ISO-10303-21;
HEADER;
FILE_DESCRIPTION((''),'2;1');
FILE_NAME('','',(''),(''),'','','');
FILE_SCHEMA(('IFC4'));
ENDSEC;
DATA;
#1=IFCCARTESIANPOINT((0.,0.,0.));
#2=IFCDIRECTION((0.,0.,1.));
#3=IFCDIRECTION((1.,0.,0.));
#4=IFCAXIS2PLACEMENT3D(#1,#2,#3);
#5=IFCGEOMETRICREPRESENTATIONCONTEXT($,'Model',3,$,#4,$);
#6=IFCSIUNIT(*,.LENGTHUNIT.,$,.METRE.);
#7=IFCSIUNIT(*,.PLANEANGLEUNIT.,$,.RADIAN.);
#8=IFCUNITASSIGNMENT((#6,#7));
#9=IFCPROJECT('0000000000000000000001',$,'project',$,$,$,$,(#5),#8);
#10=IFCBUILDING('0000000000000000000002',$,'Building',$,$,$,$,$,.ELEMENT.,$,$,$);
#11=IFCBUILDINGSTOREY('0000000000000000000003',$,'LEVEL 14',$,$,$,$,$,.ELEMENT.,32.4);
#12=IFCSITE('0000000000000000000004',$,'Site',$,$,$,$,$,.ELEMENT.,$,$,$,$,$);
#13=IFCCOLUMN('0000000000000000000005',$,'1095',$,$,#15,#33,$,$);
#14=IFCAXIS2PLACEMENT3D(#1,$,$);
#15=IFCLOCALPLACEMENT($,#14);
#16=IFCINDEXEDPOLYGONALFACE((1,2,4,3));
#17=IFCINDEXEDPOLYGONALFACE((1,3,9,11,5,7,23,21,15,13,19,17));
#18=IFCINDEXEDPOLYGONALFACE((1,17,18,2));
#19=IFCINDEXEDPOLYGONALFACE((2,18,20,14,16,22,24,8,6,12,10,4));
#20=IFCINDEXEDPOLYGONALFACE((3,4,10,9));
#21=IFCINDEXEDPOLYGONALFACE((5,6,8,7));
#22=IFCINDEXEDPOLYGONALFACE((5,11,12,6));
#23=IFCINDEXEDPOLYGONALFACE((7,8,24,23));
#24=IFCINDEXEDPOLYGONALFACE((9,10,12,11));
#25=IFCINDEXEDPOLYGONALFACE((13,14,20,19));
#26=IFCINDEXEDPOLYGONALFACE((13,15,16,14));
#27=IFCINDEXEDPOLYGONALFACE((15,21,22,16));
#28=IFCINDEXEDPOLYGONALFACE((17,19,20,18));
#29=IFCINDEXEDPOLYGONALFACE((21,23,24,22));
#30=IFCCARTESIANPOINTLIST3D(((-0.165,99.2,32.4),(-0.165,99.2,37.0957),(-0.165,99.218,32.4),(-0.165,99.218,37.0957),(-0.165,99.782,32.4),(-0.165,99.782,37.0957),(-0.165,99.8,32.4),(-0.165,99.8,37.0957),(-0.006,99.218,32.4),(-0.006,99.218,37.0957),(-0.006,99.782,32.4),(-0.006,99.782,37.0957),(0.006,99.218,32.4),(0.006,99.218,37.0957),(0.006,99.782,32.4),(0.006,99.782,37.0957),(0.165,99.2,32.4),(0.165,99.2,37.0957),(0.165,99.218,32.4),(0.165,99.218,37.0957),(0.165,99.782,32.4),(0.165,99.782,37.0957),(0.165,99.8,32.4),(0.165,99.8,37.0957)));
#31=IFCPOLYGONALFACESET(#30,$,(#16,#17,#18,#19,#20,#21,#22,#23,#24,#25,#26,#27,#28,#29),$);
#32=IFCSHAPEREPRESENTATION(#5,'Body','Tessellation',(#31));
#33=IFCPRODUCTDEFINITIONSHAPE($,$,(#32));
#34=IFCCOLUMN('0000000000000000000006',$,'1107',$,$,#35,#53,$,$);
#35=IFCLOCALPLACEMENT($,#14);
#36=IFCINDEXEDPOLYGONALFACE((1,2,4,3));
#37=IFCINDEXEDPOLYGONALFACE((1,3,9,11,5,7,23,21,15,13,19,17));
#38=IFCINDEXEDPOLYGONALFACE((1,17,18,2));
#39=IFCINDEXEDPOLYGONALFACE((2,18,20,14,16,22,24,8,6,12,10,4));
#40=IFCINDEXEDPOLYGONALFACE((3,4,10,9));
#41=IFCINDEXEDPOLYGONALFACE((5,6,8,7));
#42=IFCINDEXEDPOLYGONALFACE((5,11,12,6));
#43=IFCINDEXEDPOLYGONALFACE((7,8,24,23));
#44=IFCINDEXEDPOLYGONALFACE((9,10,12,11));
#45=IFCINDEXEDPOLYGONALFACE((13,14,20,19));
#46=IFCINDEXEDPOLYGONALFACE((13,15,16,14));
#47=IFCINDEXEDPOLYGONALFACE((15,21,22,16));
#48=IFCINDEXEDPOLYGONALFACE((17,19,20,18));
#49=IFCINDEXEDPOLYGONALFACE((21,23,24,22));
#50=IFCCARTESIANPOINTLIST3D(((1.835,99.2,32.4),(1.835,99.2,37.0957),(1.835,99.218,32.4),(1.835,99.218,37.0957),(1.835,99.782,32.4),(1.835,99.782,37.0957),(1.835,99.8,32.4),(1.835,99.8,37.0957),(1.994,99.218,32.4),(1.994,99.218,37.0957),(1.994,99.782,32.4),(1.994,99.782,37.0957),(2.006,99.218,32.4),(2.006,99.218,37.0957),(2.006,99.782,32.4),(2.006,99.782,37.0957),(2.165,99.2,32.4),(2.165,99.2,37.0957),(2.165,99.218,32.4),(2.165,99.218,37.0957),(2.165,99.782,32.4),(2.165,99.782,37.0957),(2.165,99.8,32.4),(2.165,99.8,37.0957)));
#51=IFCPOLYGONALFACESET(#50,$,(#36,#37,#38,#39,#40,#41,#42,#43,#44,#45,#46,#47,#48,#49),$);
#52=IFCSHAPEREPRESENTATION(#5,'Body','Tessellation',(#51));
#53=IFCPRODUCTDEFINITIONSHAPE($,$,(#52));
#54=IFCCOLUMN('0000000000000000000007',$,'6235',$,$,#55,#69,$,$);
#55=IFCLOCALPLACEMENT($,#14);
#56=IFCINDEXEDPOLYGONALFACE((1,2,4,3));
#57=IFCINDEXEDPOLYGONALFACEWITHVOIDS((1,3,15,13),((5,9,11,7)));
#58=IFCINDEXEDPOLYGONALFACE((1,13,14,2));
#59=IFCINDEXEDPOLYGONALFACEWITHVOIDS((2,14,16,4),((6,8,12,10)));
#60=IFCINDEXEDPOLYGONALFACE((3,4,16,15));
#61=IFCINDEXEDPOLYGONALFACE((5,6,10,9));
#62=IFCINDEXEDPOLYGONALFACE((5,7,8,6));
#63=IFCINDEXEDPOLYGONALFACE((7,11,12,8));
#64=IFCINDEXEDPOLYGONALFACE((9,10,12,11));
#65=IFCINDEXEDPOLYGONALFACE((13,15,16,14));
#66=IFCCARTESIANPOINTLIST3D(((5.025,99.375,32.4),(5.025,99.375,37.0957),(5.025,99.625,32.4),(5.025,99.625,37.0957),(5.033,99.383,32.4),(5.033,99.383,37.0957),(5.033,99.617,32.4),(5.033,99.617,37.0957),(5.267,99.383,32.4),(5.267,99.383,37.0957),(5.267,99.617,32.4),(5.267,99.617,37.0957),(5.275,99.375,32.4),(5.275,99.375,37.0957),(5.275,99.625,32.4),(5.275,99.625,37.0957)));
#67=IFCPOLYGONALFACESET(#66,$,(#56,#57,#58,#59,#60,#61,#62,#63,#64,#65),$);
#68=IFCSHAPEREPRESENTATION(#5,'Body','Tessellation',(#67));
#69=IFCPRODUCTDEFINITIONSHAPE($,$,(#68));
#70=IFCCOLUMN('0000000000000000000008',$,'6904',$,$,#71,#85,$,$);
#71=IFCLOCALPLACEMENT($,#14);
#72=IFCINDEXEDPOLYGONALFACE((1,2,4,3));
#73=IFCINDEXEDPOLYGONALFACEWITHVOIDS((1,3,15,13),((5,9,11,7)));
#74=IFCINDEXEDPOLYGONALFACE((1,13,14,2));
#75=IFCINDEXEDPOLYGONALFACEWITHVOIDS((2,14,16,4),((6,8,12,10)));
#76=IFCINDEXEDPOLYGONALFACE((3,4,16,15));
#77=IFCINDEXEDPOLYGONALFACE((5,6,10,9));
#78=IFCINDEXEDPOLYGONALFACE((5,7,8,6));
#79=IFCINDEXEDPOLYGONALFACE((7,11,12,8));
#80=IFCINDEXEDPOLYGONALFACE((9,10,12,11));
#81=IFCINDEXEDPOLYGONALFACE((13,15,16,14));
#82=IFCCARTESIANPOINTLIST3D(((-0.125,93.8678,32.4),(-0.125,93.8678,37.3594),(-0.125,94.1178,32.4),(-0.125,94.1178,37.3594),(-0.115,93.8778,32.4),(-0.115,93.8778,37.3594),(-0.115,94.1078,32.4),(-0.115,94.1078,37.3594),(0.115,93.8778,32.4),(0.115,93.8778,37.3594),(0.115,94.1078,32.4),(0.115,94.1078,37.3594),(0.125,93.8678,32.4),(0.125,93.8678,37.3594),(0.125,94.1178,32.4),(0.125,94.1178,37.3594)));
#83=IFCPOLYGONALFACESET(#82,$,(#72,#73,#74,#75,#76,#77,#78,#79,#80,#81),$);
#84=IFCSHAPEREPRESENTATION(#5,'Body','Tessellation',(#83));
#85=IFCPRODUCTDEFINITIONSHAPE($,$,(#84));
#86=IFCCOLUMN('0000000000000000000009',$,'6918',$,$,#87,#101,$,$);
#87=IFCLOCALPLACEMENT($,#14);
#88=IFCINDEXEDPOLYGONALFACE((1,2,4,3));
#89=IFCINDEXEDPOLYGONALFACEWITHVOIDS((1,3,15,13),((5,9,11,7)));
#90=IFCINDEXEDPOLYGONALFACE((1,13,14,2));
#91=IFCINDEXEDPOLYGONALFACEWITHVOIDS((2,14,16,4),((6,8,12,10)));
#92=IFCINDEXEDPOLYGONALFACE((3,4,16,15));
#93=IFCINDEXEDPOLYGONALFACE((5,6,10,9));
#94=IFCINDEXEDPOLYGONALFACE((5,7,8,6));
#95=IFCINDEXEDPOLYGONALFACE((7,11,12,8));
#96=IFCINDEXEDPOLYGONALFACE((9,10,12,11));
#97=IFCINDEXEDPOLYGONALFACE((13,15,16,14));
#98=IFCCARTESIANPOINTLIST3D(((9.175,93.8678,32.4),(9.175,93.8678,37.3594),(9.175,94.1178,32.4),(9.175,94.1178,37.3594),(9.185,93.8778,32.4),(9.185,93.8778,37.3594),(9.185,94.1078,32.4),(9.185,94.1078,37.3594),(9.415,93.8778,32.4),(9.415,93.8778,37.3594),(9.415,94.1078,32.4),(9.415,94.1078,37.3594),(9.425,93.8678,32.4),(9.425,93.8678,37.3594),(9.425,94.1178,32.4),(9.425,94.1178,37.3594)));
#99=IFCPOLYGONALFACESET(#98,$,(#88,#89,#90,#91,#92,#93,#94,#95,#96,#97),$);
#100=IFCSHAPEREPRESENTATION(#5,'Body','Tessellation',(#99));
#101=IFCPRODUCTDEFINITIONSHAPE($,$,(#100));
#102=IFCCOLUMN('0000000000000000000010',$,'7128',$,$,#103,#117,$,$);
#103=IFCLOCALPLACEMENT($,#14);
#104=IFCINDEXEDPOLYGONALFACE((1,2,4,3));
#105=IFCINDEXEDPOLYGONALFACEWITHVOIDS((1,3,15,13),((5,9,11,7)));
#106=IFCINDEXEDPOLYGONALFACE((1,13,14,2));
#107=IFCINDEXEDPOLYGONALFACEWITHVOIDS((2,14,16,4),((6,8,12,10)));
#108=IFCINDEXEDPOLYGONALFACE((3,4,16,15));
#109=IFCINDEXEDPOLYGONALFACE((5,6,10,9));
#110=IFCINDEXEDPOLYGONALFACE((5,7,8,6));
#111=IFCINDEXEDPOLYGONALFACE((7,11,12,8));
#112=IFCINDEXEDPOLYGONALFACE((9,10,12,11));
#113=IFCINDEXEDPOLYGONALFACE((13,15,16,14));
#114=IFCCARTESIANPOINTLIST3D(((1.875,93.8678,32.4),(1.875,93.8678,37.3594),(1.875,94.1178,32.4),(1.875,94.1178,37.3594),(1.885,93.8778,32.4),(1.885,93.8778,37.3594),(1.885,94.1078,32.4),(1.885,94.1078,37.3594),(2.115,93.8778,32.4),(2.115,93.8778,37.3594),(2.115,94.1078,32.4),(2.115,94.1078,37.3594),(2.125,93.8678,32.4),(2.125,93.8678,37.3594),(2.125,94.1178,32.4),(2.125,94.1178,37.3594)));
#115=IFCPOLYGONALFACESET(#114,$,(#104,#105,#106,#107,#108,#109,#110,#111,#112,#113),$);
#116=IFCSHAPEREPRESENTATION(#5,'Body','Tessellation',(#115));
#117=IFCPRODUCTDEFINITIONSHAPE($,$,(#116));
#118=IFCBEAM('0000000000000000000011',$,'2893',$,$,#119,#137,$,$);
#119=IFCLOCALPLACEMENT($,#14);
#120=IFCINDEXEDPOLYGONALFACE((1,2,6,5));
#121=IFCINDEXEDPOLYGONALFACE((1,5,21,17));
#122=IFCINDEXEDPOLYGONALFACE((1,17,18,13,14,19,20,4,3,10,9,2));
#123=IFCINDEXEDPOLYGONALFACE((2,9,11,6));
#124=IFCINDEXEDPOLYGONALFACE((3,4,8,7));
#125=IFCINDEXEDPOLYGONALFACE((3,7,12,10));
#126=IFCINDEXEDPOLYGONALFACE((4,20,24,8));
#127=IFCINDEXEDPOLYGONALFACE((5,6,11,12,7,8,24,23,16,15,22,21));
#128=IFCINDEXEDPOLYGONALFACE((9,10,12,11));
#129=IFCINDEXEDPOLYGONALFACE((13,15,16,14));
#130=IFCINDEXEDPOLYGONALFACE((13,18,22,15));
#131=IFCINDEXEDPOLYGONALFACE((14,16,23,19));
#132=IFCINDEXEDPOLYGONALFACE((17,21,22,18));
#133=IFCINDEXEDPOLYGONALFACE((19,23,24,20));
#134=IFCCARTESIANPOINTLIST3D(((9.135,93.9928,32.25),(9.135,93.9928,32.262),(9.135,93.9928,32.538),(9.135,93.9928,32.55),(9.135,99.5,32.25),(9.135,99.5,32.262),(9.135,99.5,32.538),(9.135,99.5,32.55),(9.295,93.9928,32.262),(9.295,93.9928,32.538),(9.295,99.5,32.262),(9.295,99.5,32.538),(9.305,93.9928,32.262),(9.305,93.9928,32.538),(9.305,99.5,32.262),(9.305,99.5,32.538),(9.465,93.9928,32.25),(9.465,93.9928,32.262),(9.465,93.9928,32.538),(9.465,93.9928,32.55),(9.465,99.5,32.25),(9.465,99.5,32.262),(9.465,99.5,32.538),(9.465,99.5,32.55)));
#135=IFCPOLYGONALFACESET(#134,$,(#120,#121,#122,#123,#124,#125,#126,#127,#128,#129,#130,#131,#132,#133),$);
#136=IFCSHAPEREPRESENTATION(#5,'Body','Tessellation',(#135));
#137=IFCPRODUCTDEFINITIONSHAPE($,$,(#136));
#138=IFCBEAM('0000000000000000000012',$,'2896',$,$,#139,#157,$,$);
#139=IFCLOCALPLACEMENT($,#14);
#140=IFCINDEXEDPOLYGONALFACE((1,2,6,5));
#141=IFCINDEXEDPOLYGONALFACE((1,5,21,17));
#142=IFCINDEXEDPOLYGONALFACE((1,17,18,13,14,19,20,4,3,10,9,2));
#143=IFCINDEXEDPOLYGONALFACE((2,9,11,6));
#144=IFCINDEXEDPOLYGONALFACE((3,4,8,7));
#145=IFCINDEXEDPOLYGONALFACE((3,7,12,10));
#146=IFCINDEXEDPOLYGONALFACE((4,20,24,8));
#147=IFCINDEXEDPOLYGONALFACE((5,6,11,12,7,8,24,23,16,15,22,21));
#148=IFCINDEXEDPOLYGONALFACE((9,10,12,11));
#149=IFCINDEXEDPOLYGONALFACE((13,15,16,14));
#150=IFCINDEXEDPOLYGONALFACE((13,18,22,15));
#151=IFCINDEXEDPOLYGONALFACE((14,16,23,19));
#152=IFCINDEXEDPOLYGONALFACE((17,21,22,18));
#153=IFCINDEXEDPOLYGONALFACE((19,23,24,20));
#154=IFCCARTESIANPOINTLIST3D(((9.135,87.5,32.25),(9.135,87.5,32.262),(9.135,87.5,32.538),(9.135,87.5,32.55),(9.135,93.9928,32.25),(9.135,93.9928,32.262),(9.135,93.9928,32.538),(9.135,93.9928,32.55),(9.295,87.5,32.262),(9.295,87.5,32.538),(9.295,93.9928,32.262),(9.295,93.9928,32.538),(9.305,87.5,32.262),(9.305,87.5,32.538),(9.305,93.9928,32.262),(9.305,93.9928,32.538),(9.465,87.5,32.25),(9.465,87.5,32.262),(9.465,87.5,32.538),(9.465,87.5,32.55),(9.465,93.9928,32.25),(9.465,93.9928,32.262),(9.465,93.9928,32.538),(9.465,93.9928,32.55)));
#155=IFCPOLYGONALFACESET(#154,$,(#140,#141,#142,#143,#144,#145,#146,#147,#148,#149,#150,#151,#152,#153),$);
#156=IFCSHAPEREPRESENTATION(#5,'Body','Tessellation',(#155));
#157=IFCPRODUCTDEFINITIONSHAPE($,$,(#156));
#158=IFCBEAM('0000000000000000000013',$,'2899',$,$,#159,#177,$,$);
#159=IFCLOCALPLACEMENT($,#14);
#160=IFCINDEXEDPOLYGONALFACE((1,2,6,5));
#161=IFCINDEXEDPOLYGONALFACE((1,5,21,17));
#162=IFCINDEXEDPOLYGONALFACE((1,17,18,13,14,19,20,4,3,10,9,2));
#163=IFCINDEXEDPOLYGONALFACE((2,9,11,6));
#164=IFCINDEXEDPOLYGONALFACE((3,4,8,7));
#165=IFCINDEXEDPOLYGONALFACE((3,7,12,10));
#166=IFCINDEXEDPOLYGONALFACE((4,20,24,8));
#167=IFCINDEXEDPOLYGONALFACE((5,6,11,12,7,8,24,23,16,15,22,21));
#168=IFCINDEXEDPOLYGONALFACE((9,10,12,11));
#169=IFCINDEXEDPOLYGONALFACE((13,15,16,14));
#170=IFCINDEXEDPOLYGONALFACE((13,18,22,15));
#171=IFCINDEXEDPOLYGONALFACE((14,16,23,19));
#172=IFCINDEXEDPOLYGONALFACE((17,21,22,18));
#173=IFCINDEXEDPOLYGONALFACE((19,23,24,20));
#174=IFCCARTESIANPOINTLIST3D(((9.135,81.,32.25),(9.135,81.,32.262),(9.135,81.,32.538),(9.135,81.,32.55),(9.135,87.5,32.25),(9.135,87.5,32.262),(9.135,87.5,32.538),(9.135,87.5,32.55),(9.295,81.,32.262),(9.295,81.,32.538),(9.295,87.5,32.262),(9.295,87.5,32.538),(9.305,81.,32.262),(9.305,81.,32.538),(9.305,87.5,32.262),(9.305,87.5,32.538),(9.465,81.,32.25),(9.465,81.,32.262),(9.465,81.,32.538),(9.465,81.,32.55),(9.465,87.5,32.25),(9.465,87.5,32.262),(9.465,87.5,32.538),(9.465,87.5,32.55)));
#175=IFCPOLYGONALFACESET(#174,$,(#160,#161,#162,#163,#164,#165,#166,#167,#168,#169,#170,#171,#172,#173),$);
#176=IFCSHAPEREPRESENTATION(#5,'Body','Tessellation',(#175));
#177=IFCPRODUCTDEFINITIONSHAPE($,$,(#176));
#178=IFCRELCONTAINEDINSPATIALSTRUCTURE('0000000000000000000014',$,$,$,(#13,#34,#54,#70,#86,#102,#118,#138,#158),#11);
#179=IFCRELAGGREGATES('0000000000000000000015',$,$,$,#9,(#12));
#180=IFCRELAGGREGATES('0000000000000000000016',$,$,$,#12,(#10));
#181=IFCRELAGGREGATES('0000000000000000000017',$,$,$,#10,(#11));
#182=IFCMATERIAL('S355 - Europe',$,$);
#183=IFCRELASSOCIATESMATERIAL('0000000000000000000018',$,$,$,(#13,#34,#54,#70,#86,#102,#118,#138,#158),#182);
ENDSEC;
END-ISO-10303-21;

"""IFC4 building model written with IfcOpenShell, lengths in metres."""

from ifc_helpers import new_model, si_unit, frame, origin_with_axes, origin_2d_with_axis, place, context, project, spatial, hollow_rectangle, i_section, extrude, material, material_profile, profile_set, profile_usage, element, save


model = new_model("IFC4")

# Units and contexts
model_context = context("Model", 3, world=origin_with_axes())
ifc_project = project(units=[si_unit("LENGTHUNIT", "METRE"), si_unit("PLANEANGLEUNIT", "RADIAN")], contexts=[model_context])

# Site, building, storey
site = spatial("IfcSite", under=ifc_project, Name="Site", CompositionType="ELEMENT")
building = spatial("IfcBuilding", under=site, Name="Building", CompositionType="ELEMENT")
storey = spatial("IfcBuildingStorey", under=building, Name="LEVEL 14", CompositionType="ELEMENT", Elevation=32.4)

# Columns
ifc_material = material(Name="S355 - Europe")
ifc_material_profile_1 = material_profile(ifc_material, i_section(OverallWidth=0.33, OverallDepth=0.6, WebThickness=0.012, FlangeThickness=0.018, at=origin_2d_with_axis()))
ifc_profile_set_1 = profile_set([ifc_material_profile_1])
ifc_profile_usage_1 = profile_usage(ifc_profile_set_1, cardinal=10)
column_1_placement = place(None, frame((0.0, 99.5, 32.4), z_axis=(0.0, 0.0, 1.0), x_axis=(1.0, 0.0, 0.0)))
element("IfcColumn", 1, at=column_1_placement, inside=storey, material=ifc_profile_usage_1, Name="1095", context=model_context, shape_type="SweptSolid", body=[
    extrude(i_section(OverallWidth=0.33, OverallDepth=0.6, WebThickness=0.012, FlangeThickness=0.018, at=origin_2d_with_axis()), origin_with_axes(), (0.0, 0.0, 1.0), 4.6957),
])
ifc_material_profile_2 = material_profile(ifc_material, i_section(OverallWidth=0.33, OverallDepth=0.6, WebThickness=0.012, FlangeThickness=0.018, at=origin_2d_with_axis()))
ifc_profile_set_2 = profile_set([ifc_material_profile_2])
ifc_profile_usage_2 = profile_usage(ifc_profile_set_2, cardinal=10)
column_2_placement = place(None, frame((2.0, 99.5, 32.4), z_axis=(0.0, 0.0, 1.0), x_axis=(1.0, 0.0, 0.0)))
element("IfcColumn", 2, at=column_2_placement, inside=storey, material=ifc_profile_usage_2, Name="1107", context=model_context, shape_type="SweptSolid", body=[
    extrude(i_section(OverallWidth=0.33, OverallDepth=0.6, WebThickness=0.012, FlangeThickness=0.018, at=origin_2d_with_axis()), origin_with_axes(), (0.0, 0.0, 1.0), 4.6957),
])
ifc_material_profile_3 = material_profile(ifc_material, hollow_rectangle(XDim=0.25, YDim=0.25, WallThickness=0.008, at=origin_2d_with_axis()))
ifc_profile_set_3 = profile_set([ifc_material_profile_3])
ifc_profile_usage_3 = profile_usage(ifc_profile_set_3, cardinal=10)
column_3_placement = place(None, frame((5.15, 99.5, 32.4), z_axis=(0.0, 0.0, 1.0), x_axis=(0.0, -1.0, 0.0)))
element("IfcColumn", 3, at=column_3_placement, inside=storey, material=ifc_profile_usage_3, Name="6235", context=model_context, shape_type="SweptSolid", body=[
    extrude(hollow_rectangle(XDim=0.25, YDim=0.25, WallThickness=0.008, at=origin_2d_with_axis()), origin_with_axes(), (0.0, 0.0, 1.0), 4.6957),
])
ifc_material_profile_4 = material_profile(ifc_material, hollow_rectangle(XDim=0.25, YDim=0.25, WallThickness=0.01, at=origin_2d_with_axis()))
ifc_profile_set_4 = profile_set([ifc_material_profile_4])
ifc_profile_usage_4 = profile_usage(ifc_profile_set_4, cardinal=10)
column_4_placement = place(None, frame((0.0, 93.9928, 32.4), z_axis=(0.0, 0.0, 1.0), x_axis=(0.0, -1.0, 0.0)))
element("IfcColumn", 4, at=column_4_placement, inside=storey, material=ifc_profile_usage_4, Name="6904", context=model_context, shape_type="SweptSolid", body=[
    extrude(hollow_rectangle(XDim=0.25, YDim=0.25, WallThickness=0.01, at=origin_2d_with_axis()), origin_with_axes(), (0.0, 0.0, 1.0), 4.9594),
])
ifc_material_profile_5 = material_profile(ifc_material, hollow_rectangle(XDim=0.25, YDim=0.25, WallThickness=0.01, at=origin_2d_with_axis()))
ifc_profile_set_5 = profile_set([ifc_material_profile_5])
ifc_profile_usage_5 = profile_usage(ifc_profile_set_5, cardinal=10)
column_5_placement = place(None, frame((9.3, 93.9928, 32.4), z_axis=(0.0, 0.0, 1.0), x_axis=(0.0, -1.0, 0.0)))
element("IfcColumn", 5, at=column_5_placement, inside=storey, material=ifc_profile_usage_5, Name="6918", context=model_context, shape_type="SweptSolid", body=[
    extrude(hollow_rectangle(XDim=0.25, YDim=0.25, WallThickness=0.01, at=origin_2d_with_axis()), origin_with_axes(), (0.0, 0.0, 1.0), 4.9594),
])
ifc_material_profile_6 = material_profile(ifc_material, hollow_rectangle(XDim=0.25, YDim=0.25, WallThickness=0.01, at=origin_2d_with_axis()))
ifc_profile_set_6 = profile_set([ifc_material_profile_6])
ifc_profile_usage_6 = profile_usage(ifc_profile_set_6, cardinal=10)
column_6_placement = place(None, frame((2.0, 93.9928, 32.4), z_axis=(0.0, 0.0, 1.0), x_axis=(0.0, -1.0, 0.0)))
element("IfcColumn", 6, at=column_6_placement, inside=storey, material=ifc_profile_usage_6, Name="7128", context=model_context, shape_type="SweptSolid", body=[
    extrude(hollow_rectangle(XDim=0.25, YDim=0.25, WallThickness=0.01, at=origin_2d_with_axis()), origin_with_axes(), (0.0, 0.0, 1.0), 4.9594),
])

# Beams
ifc_material_profile_7 = material_profile(ifc_material, i_section(OverallWidth=0.33, OverallDepth=0.3, WebThickness=0.01, FlangeThickness=0.012, at=origin_2d_with_axis()))
ifc_profile_set_7 = profile_set([ifc_material_profile_7])
ifc_profile_usage_7 = profile_usage(ifc_profile_set_7, cardinal=10)
beam_1_placement = place(None, frame((9.3, 93.9928, 32.4), z_axis=(0.0, 1.0, 0.0), x_axis=(-1.0, 0.0, 0.0)))
element("IfcBeam", 7, at=beam_1_placement, inside=storey, material=ifc_profile_usage_7, Name="2893", context=model_context, shape_type="SweptSolid", body=[
    extrude(i_section(OverallWidth=0.33, OverallDepth=0.3, WebThickness=0.01, FlangeThickness=0.012, at=origin_2d_with_axis()), origin_with_axes(), (0.0, 0.0, 1.0), 5.5072),
])
ifc_material_profile_8 = material_profile(ifc_material, i_section(OverallWidth=0.33, OverallDepth=0.3, WebThickness=0.01, FlangeThickness=0.012, at=origin_2d_with_axis()))
ifc_profile_set_8 = profile_set([ifc_material_profile_8])
ifc_profile_usage_8 = profile_usage(ifc_profile_set_8, cardinal=10)
beam_2_placement = place(None, frame((9.3, 93.9928, 32.4), z_axis=(0.0, -1.0, 0.0), x_axis=(1.0, 0.0, 0.0)))
element("IfcBeam", 8, at=beam_2_placement, inside=storey, material=ifc_profile_usage_8, Name="2896", context=model_context, shape_type="SweptSolid", body=[
    extrude(i_section(OverallWidth=0.33, OverallDepth=0.3, WebThickness=0.01, FlangeThickness=0.012, at=origin_2d_with_axis()), origin_with_axes(), (0.0, 0.0, 1.0), 6.4928),
])
ifc_material_profile_9 = material_profile(ifc_material, i_section(OverallWidth=0.33, OverallDepth=0.3, WebThickness=0.01, FlangeThickness=0.012, at=origin_2d_with_axis()))
ifc_profile_set_9 = profile_set([ifc_material_profile_9])
ifc_profile_usage_9 = profile_usage(ifc_profile_set_9, cardinal=10)
beam_3_placement = place(None, frame((9.3, 87.5, 32.4), z_axis=(0.0, -1.0, 0.0), x_axis=(1.0, 0.0, 0.0)))
element("IfcBeam", 9, at=beam_3_placement, inside=storey, material=ifc_profile_usage_9, Name="2899", context=model_context, shape_type="SweptSolid", body=[
    extrude(i_section(OverallWidth=0.33, OverallDepth=0.3, WebThickness=0.01, FlangeThickness=0.012, at=origin_2d_with_axis()), origin_with_axes(), (0.0, 0.0, 1.0), 6.5),
])

save(model, "model.ifc")
